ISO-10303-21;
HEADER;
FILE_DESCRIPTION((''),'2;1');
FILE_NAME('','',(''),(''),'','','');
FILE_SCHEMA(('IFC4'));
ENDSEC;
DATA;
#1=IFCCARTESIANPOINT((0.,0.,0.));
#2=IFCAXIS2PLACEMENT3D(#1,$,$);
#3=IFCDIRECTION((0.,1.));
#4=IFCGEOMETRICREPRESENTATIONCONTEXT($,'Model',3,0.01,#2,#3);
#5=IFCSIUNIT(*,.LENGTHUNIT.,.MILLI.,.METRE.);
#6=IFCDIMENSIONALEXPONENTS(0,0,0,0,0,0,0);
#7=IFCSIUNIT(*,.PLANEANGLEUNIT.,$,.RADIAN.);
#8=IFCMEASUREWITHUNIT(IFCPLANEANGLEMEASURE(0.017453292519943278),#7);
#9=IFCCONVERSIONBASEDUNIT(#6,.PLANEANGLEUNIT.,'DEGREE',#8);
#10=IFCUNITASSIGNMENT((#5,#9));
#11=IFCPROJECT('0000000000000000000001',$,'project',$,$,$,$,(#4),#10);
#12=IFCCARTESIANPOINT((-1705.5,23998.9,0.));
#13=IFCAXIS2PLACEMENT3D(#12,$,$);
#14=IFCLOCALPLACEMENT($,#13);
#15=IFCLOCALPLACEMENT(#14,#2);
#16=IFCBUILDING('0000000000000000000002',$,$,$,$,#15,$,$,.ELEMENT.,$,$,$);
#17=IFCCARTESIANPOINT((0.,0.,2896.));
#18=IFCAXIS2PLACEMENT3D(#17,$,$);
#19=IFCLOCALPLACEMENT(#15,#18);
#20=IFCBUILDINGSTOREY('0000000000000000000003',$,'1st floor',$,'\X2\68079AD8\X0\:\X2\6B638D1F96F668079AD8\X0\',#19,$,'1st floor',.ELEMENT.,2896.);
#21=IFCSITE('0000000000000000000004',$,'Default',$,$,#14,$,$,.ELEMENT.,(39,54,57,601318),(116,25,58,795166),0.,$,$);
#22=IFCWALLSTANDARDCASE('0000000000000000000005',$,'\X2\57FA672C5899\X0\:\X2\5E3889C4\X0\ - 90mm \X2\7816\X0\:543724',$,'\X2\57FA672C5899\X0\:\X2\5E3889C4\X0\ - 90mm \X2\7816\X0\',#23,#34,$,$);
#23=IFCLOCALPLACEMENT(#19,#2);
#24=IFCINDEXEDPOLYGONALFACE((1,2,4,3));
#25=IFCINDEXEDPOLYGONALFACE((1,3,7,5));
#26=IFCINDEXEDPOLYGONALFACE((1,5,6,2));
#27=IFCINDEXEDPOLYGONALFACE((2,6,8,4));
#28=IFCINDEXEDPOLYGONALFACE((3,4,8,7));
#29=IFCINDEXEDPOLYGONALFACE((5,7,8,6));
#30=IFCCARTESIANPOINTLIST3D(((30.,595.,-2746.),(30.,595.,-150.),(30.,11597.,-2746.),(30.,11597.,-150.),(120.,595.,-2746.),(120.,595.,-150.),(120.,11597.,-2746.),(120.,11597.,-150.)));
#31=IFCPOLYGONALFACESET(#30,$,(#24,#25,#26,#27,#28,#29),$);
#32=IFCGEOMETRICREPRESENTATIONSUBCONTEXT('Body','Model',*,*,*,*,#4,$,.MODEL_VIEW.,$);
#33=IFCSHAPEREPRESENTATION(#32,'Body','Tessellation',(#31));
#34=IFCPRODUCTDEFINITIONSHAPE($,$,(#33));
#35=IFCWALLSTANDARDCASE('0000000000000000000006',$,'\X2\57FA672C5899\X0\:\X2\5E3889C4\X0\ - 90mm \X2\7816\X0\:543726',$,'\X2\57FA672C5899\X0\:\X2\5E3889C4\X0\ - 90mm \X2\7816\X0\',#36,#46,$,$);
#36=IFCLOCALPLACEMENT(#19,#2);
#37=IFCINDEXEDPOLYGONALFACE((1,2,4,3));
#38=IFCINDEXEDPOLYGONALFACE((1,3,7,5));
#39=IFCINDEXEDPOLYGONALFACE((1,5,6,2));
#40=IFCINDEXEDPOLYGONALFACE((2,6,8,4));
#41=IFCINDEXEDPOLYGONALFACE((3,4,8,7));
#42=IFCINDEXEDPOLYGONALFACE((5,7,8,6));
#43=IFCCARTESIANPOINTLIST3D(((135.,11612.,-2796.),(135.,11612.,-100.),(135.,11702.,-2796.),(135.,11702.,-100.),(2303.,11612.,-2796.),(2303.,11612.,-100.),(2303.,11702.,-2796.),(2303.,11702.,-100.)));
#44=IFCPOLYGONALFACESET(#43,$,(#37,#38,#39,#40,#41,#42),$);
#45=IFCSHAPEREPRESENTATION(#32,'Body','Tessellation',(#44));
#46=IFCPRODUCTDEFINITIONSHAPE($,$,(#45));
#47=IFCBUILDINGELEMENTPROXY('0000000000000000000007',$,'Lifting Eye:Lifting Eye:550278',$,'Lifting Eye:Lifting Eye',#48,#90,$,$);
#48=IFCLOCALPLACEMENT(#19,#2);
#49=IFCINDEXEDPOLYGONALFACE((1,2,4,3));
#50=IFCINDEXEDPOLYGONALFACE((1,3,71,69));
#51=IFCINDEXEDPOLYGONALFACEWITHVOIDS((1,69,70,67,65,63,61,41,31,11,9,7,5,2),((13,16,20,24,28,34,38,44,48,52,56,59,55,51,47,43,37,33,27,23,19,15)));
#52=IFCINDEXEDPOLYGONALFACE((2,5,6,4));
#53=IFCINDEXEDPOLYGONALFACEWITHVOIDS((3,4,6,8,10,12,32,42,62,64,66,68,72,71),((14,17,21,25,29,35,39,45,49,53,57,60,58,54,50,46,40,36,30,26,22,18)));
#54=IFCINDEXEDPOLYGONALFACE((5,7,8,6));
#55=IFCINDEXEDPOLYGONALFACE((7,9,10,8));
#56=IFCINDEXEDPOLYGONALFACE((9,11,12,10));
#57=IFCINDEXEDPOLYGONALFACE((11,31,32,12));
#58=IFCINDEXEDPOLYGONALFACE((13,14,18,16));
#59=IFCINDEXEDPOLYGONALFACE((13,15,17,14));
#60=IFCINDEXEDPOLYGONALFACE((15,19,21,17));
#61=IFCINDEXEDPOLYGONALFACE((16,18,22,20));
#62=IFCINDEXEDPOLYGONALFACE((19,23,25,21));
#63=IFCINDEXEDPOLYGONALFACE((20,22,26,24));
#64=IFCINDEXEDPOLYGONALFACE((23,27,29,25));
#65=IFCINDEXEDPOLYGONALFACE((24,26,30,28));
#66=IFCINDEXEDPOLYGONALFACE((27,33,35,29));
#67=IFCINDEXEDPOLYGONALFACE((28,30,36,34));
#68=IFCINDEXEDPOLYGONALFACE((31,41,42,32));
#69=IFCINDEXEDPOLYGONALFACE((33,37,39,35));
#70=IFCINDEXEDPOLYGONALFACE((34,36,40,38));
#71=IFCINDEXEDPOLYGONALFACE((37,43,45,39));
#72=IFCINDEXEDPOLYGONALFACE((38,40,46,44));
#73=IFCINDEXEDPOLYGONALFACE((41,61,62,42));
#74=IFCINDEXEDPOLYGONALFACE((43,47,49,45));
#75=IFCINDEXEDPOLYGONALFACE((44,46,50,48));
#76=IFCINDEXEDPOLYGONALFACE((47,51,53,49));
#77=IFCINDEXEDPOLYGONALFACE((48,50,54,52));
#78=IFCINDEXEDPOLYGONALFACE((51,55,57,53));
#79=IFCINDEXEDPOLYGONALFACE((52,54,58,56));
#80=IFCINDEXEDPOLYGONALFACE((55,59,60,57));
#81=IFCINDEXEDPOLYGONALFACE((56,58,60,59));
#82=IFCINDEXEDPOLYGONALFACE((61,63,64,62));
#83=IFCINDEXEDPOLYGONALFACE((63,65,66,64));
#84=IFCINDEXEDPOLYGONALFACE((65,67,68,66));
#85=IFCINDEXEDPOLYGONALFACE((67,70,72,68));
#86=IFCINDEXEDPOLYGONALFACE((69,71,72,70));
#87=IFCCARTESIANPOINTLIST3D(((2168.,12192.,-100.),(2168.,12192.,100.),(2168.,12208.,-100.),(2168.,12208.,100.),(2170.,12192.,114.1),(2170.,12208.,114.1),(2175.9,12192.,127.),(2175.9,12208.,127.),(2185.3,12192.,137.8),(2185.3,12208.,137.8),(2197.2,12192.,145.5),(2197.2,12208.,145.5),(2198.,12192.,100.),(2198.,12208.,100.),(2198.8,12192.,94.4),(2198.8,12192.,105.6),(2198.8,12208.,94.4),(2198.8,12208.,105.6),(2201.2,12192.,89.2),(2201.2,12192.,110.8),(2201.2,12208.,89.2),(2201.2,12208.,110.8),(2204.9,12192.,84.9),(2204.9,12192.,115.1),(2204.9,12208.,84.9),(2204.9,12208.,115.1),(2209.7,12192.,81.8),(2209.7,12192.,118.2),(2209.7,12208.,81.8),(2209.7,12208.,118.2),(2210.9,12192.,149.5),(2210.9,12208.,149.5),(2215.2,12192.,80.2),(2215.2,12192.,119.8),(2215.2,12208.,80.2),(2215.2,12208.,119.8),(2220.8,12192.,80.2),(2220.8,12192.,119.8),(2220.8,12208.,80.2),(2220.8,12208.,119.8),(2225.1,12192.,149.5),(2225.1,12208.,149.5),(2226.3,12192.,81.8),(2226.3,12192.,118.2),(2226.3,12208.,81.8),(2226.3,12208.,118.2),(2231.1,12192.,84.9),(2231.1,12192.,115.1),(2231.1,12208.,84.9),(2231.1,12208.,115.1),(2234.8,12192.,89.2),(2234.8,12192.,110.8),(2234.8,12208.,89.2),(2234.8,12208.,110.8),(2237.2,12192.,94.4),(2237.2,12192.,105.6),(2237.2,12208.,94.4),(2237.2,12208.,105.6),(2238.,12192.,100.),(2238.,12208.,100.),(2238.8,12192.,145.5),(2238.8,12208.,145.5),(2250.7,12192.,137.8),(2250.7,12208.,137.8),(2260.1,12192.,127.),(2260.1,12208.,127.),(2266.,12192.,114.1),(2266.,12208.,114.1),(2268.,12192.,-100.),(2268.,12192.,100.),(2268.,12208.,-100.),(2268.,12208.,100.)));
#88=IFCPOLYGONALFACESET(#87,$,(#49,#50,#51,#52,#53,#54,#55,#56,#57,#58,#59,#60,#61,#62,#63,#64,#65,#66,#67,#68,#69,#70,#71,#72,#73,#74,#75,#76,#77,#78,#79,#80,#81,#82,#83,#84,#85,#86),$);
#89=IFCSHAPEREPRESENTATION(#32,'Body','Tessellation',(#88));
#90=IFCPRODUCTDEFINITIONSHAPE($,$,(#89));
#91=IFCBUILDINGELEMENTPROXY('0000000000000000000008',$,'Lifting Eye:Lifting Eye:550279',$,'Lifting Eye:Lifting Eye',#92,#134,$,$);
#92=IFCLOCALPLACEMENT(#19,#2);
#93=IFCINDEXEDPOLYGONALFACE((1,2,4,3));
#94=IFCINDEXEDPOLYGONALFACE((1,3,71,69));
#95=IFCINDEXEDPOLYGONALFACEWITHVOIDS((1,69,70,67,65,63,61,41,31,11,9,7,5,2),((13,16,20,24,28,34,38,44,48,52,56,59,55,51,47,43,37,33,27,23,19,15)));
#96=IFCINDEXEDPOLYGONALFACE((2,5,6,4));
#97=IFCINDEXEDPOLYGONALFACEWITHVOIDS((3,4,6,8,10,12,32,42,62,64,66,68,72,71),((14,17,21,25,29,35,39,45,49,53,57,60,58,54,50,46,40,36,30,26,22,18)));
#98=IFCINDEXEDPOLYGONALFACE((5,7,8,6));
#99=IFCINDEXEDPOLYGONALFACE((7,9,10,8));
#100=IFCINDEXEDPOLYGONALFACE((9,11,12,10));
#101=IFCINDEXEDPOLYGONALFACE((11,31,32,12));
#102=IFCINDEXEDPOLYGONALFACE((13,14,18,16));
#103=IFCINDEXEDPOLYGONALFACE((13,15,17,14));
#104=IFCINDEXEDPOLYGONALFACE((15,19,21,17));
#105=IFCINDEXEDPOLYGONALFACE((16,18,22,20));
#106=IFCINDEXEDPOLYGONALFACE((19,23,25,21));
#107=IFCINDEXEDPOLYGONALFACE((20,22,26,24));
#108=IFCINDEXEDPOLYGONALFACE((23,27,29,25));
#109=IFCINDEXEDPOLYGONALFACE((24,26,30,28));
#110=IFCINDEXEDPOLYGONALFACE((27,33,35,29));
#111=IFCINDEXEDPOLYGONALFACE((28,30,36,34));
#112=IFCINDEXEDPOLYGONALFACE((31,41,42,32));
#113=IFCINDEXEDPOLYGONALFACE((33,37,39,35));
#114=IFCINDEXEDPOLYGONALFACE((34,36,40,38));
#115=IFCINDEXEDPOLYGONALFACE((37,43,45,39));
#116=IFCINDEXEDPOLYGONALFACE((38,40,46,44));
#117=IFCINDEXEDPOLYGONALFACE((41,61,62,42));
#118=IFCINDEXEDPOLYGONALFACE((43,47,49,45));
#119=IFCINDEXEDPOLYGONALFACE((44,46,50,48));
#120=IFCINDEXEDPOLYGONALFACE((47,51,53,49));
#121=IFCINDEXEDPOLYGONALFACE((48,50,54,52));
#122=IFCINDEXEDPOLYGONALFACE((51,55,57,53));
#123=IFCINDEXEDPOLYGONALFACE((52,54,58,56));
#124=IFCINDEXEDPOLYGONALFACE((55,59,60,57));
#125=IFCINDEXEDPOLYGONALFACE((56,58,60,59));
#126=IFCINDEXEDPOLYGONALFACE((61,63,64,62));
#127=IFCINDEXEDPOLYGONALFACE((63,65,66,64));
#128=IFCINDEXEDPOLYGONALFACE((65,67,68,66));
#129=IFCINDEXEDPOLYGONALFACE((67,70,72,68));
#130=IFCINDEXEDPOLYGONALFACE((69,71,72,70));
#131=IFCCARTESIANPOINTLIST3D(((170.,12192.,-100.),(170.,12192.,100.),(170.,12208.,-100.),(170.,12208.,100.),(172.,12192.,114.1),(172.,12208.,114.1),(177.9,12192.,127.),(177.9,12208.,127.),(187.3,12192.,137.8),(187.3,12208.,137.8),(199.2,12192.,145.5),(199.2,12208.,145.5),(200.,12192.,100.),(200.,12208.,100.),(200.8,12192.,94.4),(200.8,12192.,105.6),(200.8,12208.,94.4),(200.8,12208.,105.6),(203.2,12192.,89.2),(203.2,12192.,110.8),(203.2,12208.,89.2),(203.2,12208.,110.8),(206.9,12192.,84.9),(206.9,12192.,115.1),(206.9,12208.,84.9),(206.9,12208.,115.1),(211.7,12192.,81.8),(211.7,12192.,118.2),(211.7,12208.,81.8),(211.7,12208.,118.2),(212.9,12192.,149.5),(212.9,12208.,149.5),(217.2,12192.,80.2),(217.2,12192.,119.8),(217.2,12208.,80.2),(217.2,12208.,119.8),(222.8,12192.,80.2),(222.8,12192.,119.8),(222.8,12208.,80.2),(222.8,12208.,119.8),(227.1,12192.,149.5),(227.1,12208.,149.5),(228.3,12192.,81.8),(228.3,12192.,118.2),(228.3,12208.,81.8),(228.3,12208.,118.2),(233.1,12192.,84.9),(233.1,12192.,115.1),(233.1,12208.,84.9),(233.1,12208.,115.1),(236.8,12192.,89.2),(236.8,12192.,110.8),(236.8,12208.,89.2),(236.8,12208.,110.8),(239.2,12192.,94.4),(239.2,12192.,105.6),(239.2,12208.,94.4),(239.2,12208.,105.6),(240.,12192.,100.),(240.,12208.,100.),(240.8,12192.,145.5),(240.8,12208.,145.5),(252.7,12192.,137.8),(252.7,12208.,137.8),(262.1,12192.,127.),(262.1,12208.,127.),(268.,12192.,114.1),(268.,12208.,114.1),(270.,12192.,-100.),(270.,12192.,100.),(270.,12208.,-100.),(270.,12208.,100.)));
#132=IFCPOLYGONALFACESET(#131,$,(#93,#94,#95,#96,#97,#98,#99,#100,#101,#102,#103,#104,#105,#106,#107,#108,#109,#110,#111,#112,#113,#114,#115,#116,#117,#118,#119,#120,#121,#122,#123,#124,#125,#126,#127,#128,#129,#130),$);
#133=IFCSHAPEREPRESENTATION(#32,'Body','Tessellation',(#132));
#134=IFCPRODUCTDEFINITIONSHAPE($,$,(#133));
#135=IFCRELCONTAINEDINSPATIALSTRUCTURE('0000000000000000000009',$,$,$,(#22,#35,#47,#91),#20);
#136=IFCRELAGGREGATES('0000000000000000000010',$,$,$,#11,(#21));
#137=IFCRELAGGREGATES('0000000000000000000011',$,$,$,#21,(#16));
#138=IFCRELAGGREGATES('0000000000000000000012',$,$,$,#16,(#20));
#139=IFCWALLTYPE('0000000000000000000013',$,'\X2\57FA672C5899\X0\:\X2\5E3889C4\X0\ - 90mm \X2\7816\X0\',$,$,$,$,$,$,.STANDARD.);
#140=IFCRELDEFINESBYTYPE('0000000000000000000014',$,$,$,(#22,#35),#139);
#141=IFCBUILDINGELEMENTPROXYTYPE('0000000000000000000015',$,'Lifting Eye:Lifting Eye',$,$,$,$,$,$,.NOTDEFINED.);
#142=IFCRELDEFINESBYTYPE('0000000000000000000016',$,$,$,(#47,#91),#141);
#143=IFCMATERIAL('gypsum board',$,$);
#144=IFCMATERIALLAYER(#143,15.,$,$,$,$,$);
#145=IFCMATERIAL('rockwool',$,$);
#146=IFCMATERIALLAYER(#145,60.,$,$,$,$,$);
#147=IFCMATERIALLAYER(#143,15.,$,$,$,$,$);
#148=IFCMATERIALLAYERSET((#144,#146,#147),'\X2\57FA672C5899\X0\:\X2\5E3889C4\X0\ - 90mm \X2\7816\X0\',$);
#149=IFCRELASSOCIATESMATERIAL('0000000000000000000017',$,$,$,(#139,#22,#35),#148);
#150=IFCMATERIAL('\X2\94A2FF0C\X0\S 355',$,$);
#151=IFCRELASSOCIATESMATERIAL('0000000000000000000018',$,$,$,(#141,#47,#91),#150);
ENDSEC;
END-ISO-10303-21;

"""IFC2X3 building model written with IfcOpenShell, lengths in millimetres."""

from ifc_helpers import new_model, entity, si_unit, converted_unit, direction, frame, frame_2d, origin, place, context, subcontext, project, spatial, polyline, circle_curve, parameter, trimmed, segment, composite_curve, rectangle, outline, extrude, source, transform, mapped, material, layer, layer_set, layer_usage, type_object, type_shapes, element, save


model = new_model("IFC2X3")

# Units and contexts
model_context = context("Model", 3, precision=0.01, world=origin(), true_north=direction((0.0, 1.0)))
body_context = subcontext(model_context, "Body", "Model", "MODEL_VIEW")
ifc_project = project(units=[si_unit("LENGTHUNIT", "METRE", prefix="MILLI"), converted_unit("PLANEANGLEUNIT", "DEGREE", entity("IfcPlaneAngleMeasure", 0.017453292519943278), si_unit("PLANEANGLEUNIT", "RADIAN"), dimensions=[0, 0, 0, 0, 0, 0, 0])], contexts=[model_context])

# Site, building, storey
site_placement = place(None, frame((-1705.5, 23998.9, 0.0)))
site = spatial("IfcSite", under=ifc_project, at=site_placement, Name="Default", CompositionType="ELEMENT", RefLatitude=(39, 54, 57, 601318), RefLongitude=(116, 25, 58, 795166), RefElevation=0.0)
building_placement = place(site_placement, origin())
building = spatial("IfcBuilding", under=site, at=building_placement, CompositionType="ELEMENT")
storey_placement = place(building_placement, frame((0.0, 0.0, 2896.0)))
storey = spatial("IfcBuildingStorey", under=building, at=storey_placement, Name="1st floor", ObjectType="标高:正负零标高", LongName="1st floor", CompositionType="ELEMENT", Elevation=2896.0)

# Wall
ifc_material_1 = material(Name="gypsum board")
ifc_layer_1 = layer(ifc_material_1, 15.0)
ifc_material_2 = material(Name="rockwool")
ifc_layer_2 = layer(ifc_material_2, 60.0)
ifc_layer_3 = layer(ifc_material_1, 15.0)
ifc_layer_set = layer_set([ifc_layer_1, ifc_layer_2, ifc_layer_3], Name="基本墙:常规 - 90mm 砖")
ifc_layer_usage_1 = layer_usage(ifc_layer_set, "AXIS2", "NEGATIVE", 45.0)
wall_type = type_object("IfcWallType", Name="基本墙:常规 - 90mm 砖", PredefinedType="STANDARD", material=ifc_layer_set)
wall_1_placement = place(storey_placement, frame((75.0, 11597.0, -2746.0), z_axis=(0.0, 0.0, 1.0), x_axis=(0.0, -1.0, 0.0)))
element("IfcWallStandardCase", 1, at=wall_1_placement, inside=storey, type_object=wall_type, material=ifc_layer_usage_1, Name="基本墙:常规 - 90mm 砖:543724", ObjectType="基本墙:常规 - 90mm 砖", context=body_context, shape_type="SweptSolid", body=[
    extrude(rectangle(XDim=11002.0, YDim=90.0, at=frame_2d((5501.0, 0.0), x_axis=(-1.0, 0.0))), origin(), (0.0, 0.0, 1.0), 2596.0),
])

# Wall
ifc_layer_usage_2 = layer_usage(ifc_layer_set, "AXIS2", "NEGATIVE", 45.0)
wall_2_placement = place(storey_placement, frame((2303.0, 11657.0, -2796.0), z_axis=(0.0, 0.0, 1.0), x_axis=(-1.0, 0.0, 0.0)))
element("IfcWallStandardCase", 2, at=wall_2_placement, inside=storey, type_object=wall_type, material=ifc_layer_usage_2, Name="基本墙:常规 - 90mm 砖:543726", ObjectType="基本墙:常规 - 90mm 砖", context=body_context, shape_type="SweptSolid", body=[
    extrude(rectangle(XDim=2168.0, YDim=90.0, at=frame_2d((1084.0, 0.0), x_axis=(-1.0, 0.0))), origin(), (0.0, 0.0, 1.0), 2696.0),
])

# Building element proxies
ifc_material_3 = material(Name="钢，S 355")
building_element_proxy_type_1 = type_object("IfcBuildingElementProxyType", Name="Lifting Eye:Lifting Eye", PredefinedType="NOTDEFINED", material=ifc_material_3)
shared_shape_1 = source(origin(), body_context, "Body", "SweptSolid", [
    extrude(outline(composite_curve([segment(polyline([(-100.0, -50.0), (100.0, -50.0)]), True, "CONTINUOUS"), segment(polyline([(100.0, -50.0), (100.0, 50.0)]), True, "CONTINUOUS"), segment(polyline([(100.0, 50.0), (-100.0, 50.0)]), True, "CONTINUOUS"), segment(trimmed(circle_curve(frame_2d((-100.0, 0.0), x_axis=(0.0, -1.0)), 50.0), [parameter(180.0)], [parameter(0.0)], True, "PARAMETER"), True, "CONTINUOUS")], self_intersect=False), holes=[composite_curve([segment(trimmed(circle_curve(frame_2d((-100.0, 0.0), x_axis=(0.0, -1.0)), 20.0), [parameter(180.0)], [parameter(360.0)], True, "PARAMETER"), False, "CONTINUOUS"), segment(trimmed(circle_curve(frame_2d((-100.0, 0.0), x_axis=(0.0, -1.0)), 20.0), [parameter(0.0)], [parameter(180.0)], True, "PARAMETER"), False, "CONTINUOUS")], self_intersect=False)]), frame((0.0, 17.0, -17.0), z_axis=(0.0, 1.0, 0.0), x_axis=(0.0, 0.0, -1.0)), (0.0, 0.0, 1.0), 16.0),
])
type_shapes(building_element_proxy_type_1, [shared_shape_1])
for number, where, name in (
    (3, (2218.0, 12175.0, 17.0), "Lifting Eye:Lifting Eye:550278"),
    (4, (220.0, 12175.0, 17.0), "Lifting Eye:Lifting Eye:550279"),
):
    element("IfcBuildingElementProxy", number, at=place(storey_placement, frame(where)), inside=storey, type_object=building_element_proxy_type_1, material=ifc_material_3, Name=name, ObjectType="Lifting Eye:Lifting Eye", context=body_context, shape_type="MappedRepresentation", body=[
        mapped(shared_shape_1, transform((0.0, 0.0, 0.0), scale=1.0)),
    ])

save(model, "model.ifc")
